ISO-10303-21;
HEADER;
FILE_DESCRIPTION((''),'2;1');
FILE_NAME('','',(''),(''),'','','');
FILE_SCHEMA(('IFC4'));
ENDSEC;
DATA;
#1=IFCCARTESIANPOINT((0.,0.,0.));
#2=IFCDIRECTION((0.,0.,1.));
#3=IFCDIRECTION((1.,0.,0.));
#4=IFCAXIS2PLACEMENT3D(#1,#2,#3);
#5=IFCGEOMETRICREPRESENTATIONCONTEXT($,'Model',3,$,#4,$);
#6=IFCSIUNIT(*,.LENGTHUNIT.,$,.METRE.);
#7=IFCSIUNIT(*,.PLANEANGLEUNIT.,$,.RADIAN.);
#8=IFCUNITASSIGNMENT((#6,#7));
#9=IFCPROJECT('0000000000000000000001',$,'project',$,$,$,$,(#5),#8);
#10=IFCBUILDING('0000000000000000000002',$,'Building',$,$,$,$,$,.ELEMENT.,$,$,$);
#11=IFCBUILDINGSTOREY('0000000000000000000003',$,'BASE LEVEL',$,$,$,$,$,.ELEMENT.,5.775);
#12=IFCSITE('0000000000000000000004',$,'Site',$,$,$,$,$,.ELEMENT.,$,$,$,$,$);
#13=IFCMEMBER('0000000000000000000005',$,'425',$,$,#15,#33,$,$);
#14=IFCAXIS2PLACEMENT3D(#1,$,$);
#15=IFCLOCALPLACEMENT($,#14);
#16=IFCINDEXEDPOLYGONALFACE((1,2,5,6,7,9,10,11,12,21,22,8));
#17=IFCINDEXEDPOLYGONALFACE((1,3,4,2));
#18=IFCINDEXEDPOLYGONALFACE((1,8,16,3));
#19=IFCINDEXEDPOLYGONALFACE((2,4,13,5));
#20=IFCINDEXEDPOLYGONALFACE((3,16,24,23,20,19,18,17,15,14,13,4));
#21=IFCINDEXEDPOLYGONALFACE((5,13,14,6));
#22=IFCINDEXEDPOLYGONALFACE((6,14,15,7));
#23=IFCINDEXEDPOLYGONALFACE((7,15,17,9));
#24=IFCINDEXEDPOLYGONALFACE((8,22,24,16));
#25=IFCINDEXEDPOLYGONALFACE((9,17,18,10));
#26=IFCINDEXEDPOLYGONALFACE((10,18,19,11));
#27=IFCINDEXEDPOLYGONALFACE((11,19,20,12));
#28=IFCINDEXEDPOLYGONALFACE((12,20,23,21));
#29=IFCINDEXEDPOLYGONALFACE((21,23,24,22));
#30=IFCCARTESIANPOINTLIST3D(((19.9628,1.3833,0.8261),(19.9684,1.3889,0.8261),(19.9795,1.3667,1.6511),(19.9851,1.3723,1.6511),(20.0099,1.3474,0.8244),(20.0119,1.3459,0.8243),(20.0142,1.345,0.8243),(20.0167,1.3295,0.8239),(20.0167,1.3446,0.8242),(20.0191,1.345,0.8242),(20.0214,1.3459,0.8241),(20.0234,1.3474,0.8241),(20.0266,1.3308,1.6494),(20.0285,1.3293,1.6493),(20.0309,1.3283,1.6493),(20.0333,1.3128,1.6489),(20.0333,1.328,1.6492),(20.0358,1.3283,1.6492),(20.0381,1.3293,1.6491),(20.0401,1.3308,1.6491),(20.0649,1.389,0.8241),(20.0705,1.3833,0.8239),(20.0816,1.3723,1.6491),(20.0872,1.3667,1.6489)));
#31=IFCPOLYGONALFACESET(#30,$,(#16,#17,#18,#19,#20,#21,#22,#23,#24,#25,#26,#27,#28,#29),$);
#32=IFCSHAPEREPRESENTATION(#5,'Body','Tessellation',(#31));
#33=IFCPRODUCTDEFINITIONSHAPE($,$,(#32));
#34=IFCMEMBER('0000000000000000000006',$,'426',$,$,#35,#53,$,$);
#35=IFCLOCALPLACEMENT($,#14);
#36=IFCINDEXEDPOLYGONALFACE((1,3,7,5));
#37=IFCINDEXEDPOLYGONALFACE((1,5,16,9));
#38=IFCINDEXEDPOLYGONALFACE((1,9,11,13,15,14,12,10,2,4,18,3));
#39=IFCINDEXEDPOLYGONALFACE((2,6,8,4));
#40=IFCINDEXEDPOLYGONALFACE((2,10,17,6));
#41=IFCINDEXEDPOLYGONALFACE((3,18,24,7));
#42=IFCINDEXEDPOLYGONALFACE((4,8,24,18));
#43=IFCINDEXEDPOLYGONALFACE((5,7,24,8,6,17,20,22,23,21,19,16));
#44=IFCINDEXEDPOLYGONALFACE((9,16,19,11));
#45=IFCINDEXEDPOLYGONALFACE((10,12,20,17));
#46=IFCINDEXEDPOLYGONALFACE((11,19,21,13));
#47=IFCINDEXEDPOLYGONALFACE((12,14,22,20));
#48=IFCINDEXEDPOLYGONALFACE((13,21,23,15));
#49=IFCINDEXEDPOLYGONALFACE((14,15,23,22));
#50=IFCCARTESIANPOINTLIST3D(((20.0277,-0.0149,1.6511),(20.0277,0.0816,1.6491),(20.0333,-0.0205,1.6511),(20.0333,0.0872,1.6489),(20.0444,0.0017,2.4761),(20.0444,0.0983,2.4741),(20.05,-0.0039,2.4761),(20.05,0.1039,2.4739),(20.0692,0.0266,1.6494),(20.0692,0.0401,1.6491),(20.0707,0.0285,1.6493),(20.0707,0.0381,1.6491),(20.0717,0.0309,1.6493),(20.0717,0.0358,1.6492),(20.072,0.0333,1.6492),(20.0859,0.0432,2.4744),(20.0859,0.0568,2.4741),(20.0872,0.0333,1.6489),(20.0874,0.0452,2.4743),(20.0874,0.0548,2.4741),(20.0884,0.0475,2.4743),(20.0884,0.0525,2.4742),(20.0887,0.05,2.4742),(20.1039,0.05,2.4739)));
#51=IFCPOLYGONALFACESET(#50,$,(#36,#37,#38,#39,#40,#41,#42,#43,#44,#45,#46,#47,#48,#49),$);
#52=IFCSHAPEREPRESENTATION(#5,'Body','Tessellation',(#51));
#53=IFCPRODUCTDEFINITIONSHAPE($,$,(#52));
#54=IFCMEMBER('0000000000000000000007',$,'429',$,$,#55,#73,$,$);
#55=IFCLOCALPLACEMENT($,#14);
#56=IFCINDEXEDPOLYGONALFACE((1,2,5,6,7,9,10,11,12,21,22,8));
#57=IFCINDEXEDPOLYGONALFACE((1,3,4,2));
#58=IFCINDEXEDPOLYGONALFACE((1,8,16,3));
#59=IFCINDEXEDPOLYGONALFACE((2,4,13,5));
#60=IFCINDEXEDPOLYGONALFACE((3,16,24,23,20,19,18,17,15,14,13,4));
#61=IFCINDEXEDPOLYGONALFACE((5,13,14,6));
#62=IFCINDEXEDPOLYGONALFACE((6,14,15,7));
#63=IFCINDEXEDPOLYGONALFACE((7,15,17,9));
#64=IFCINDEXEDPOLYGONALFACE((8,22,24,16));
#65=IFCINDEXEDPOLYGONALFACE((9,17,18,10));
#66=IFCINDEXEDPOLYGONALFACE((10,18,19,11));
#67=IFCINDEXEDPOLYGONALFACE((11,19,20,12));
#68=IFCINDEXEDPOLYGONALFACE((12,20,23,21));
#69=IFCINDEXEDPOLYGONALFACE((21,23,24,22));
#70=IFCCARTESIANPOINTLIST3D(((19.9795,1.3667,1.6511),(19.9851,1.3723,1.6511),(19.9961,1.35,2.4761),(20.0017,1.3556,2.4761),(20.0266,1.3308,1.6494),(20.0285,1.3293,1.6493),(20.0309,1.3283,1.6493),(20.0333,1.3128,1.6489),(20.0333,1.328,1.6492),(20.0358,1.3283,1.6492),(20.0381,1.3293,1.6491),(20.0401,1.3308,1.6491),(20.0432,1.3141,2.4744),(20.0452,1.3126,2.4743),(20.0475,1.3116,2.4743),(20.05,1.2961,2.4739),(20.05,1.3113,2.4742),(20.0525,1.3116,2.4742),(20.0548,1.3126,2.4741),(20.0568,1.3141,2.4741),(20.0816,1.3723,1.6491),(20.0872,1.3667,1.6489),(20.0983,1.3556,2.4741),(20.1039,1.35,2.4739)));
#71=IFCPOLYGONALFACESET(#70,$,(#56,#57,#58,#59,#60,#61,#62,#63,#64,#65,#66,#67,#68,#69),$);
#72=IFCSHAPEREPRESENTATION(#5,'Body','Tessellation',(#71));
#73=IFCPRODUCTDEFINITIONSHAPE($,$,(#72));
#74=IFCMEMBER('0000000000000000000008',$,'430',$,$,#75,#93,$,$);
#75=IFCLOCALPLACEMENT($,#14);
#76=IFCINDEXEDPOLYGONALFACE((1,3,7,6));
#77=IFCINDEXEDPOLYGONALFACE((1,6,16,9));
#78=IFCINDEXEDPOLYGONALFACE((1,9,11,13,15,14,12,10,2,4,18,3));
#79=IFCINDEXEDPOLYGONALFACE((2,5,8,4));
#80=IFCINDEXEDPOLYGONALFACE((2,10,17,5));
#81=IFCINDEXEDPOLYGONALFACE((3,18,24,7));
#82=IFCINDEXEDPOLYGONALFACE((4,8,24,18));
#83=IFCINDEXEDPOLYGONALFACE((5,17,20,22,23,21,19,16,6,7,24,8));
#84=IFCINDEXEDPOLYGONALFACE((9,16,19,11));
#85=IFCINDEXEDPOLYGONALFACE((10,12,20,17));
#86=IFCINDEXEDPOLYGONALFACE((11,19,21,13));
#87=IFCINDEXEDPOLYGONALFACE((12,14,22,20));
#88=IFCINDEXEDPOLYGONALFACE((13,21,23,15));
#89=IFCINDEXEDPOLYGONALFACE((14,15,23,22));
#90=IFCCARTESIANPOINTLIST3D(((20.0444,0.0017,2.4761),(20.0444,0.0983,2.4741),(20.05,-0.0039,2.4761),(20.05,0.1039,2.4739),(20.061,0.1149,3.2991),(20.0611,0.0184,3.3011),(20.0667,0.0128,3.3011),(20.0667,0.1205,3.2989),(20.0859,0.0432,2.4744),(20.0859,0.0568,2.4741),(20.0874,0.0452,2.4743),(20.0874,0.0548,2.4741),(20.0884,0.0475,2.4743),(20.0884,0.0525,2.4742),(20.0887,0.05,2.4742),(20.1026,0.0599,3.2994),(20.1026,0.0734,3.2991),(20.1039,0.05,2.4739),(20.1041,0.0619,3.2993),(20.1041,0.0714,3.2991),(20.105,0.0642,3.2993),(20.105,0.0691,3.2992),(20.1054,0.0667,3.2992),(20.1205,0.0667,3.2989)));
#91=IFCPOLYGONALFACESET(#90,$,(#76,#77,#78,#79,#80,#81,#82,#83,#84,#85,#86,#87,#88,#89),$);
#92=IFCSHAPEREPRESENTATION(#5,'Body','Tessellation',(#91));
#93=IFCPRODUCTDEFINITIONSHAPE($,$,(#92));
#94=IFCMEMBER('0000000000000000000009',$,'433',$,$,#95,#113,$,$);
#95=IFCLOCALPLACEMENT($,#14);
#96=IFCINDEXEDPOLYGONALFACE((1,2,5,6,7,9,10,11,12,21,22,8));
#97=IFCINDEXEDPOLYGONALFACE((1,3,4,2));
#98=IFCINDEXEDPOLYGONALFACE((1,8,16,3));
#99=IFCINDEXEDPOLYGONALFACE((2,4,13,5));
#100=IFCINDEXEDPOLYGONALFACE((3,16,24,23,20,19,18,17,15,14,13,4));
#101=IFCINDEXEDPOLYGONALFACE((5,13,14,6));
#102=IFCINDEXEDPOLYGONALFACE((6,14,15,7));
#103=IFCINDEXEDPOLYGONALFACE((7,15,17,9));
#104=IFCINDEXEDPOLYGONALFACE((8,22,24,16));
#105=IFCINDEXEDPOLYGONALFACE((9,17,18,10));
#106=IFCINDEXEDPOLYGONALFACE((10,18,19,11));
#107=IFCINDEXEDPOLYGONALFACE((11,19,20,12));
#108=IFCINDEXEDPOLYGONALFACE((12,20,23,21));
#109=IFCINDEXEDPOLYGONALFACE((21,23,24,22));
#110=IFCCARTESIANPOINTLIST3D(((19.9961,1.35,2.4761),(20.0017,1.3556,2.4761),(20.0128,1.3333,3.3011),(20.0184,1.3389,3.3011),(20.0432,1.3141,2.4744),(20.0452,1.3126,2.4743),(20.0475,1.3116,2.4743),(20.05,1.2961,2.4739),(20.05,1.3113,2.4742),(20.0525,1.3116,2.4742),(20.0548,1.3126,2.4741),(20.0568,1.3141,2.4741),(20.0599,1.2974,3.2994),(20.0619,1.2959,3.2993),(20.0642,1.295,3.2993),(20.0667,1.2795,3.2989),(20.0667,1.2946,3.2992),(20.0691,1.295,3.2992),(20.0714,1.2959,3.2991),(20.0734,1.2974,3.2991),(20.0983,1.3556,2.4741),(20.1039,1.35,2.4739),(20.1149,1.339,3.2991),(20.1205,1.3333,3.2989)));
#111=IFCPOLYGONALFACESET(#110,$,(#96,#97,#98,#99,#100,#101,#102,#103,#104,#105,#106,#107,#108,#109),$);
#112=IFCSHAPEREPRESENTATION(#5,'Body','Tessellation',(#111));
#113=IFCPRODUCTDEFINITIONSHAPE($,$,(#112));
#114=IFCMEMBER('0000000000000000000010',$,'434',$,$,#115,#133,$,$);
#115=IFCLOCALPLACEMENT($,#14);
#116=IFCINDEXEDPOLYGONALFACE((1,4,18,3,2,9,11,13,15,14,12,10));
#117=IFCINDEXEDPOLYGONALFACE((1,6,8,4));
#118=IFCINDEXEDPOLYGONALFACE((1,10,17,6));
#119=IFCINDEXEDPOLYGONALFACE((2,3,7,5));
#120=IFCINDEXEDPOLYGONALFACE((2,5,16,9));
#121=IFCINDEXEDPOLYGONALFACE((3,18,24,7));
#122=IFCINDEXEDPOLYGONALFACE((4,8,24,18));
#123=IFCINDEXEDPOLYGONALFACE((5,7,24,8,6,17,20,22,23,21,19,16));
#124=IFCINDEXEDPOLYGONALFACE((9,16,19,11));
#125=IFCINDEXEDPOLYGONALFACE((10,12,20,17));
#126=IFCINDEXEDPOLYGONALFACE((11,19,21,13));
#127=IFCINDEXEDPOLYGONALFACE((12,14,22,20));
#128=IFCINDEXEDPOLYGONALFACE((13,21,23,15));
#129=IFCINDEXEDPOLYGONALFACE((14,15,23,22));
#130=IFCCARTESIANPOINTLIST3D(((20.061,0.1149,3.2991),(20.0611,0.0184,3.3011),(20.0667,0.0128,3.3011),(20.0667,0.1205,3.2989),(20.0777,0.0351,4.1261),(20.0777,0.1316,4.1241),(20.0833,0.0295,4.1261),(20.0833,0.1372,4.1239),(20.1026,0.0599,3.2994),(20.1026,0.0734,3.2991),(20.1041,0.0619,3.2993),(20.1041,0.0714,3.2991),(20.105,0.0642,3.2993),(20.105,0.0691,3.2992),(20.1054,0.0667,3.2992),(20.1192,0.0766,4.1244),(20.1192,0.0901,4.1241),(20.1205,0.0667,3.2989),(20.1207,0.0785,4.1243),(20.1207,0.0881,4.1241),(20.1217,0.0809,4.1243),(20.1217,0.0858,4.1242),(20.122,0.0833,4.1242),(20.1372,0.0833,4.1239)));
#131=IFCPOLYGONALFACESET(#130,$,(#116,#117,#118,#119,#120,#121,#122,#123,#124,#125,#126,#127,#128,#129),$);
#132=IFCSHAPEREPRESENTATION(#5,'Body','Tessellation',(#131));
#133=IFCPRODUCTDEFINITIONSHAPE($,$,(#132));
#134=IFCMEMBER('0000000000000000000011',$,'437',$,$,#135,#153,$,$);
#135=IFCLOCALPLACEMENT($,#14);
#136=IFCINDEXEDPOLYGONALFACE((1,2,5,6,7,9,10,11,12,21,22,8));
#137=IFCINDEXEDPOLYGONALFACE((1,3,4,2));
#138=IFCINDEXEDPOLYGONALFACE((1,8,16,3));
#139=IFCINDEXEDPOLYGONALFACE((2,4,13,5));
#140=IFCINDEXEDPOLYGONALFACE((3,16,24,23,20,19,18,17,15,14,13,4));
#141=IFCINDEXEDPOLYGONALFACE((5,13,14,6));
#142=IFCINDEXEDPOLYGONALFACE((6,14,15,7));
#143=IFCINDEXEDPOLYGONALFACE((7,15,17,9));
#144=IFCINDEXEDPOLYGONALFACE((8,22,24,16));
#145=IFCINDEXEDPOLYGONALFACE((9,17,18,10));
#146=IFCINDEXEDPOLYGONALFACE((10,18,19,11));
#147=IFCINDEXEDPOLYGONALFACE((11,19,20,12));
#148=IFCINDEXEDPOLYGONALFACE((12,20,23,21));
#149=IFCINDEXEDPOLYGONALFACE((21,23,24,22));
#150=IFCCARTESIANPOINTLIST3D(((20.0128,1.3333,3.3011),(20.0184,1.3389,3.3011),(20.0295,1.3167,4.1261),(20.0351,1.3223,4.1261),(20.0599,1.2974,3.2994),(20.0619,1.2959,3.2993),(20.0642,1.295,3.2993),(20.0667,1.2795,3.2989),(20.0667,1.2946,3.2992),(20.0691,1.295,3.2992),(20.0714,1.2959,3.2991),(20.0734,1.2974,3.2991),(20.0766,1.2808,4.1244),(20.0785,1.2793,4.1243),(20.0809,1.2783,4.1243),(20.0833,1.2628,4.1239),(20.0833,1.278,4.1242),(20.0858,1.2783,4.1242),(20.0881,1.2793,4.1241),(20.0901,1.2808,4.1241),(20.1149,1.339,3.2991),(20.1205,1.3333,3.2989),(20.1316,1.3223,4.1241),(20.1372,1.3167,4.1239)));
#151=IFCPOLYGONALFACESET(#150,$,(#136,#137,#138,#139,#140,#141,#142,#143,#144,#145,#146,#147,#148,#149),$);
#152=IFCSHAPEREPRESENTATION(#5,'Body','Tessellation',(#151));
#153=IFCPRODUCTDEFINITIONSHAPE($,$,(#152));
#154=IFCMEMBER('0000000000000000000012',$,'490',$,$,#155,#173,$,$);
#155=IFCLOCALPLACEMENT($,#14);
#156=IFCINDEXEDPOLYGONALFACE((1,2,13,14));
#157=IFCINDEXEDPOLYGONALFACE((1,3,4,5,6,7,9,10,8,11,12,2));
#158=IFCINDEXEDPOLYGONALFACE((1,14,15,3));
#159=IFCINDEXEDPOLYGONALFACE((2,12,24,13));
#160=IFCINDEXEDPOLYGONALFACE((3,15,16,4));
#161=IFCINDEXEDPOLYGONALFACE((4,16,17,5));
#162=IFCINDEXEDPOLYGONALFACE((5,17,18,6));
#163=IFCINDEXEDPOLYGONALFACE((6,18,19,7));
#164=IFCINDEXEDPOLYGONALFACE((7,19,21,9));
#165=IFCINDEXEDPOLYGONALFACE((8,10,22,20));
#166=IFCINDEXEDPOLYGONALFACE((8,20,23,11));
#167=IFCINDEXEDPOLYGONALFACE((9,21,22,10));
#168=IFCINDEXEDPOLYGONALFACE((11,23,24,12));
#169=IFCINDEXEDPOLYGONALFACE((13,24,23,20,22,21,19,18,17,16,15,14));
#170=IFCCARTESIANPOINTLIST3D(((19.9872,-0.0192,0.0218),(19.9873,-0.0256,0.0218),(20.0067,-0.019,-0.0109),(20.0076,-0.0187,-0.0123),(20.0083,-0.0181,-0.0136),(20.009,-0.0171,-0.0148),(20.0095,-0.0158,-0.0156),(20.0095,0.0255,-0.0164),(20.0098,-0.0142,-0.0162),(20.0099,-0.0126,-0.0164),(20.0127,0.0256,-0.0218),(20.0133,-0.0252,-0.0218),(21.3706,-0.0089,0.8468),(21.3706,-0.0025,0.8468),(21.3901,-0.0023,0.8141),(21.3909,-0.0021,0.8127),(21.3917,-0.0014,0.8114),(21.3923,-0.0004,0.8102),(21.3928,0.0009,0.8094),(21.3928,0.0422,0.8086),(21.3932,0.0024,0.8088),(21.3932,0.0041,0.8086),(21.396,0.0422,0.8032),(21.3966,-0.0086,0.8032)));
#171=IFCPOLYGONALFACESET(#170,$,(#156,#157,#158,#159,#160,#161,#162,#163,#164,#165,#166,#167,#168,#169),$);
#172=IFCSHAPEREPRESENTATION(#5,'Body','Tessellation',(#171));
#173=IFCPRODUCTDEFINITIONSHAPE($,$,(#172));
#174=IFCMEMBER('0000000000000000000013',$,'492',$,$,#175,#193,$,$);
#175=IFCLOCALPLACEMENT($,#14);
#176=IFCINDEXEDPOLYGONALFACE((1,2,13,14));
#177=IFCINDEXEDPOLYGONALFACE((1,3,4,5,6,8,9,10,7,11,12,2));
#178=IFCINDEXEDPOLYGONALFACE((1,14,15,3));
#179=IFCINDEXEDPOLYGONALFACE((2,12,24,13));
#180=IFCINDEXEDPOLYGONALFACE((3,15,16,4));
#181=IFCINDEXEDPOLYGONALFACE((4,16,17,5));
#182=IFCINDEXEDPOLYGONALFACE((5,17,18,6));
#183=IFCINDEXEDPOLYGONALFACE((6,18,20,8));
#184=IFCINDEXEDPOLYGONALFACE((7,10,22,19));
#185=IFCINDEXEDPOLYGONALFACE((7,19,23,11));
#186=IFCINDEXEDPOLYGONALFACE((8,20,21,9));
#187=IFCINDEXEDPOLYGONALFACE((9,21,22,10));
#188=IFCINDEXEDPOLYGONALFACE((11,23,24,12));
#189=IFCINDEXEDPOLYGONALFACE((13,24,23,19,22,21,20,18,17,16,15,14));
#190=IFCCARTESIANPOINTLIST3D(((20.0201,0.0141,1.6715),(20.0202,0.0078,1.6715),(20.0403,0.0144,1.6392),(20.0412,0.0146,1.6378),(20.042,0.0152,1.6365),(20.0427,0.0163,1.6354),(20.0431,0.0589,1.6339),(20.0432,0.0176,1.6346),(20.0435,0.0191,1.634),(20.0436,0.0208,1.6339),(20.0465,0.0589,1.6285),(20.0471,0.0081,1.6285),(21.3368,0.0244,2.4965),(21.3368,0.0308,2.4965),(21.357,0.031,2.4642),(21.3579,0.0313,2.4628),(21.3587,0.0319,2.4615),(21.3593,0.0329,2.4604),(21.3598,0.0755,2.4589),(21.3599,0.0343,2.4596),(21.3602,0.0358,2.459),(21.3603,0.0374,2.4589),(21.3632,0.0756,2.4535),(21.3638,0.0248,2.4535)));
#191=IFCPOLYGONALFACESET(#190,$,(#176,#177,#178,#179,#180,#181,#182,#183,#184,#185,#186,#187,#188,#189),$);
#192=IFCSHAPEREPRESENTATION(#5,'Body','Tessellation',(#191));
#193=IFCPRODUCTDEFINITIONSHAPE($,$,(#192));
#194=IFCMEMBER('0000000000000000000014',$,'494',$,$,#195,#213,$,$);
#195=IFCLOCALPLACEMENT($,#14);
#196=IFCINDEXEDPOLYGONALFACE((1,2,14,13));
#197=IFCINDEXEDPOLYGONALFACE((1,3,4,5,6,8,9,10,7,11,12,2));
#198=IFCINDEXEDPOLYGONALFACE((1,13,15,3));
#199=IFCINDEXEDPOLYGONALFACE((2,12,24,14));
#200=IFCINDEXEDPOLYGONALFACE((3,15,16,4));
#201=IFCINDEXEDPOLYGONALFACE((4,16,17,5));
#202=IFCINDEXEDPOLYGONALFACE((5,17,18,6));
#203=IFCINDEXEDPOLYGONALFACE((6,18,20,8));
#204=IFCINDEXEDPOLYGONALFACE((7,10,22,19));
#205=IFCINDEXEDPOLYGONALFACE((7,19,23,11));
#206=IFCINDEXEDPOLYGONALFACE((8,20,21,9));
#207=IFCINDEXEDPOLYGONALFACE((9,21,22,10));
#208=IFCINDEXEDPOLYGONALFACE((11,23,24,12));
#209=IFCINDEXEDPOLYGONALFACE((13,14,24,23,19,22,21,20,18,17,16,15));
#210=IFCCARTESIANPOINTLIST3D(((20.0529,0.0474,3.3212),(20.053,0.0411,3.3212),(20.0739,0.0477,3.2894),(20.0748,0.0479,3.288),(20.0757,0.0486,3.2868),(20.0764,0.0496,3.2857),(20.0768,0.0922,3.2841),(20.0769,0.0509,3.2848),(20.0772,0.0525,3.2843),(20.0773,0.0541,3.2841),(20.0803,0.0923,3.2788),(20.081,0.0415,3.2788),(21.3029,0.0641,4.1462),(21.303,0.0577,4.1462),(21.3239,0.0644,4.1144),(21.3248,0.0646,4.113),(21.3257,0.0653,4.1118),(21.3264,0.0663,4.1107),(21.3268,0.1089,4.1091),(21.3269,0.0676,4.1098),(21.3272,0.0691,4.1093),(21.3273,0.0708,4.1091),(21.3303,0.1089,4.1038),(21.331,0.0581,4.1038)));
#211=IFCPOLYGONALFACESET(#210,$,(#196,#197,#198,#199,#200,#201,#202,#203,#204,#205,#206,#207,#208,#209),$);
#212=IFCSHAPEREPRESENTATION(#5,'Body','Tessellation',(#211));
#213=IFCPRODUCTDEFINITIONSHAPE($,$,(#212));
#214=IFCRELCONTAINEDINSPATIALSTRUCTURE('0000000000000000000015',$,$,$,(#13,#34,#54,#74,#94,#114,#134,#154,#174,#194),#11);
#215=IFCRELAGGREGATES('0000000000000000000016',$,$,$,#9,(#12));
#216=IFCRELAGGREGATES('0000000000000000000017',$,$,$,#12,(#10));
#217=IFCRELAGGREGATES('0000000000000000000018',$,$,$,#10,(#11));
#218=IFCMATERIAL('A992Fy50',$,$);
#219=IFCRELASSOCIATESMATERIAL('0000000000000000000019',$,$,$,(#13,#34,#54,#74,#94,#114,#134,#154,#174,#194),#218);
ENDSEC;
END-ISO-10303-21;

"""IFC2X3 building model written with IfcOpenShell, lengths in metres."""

from ifc_helpers import new_model, si_unit, frame, origin_with_axes, origin_2d_with_axis, place, context, project, spatial, l_section, extrude, material, element, save


model = new_model("IFC2X3")

# Units and contexts
model_context = context("Model", 3, world=origin_with_axes())
ifc_project = project(units=[si_unit("LENGTHUNIT", "METRE"), si_unit("PLANEANGLEUNIT", "RADIAN")], contexts=[model_context])

# Site, building, storey
site = spatial("IfcSite", under=ifc_project, Name="Site", CompositionType="ELEMENT")
building = spatial("IfcBuilding", under=site, Name="Building", CompositionType="ELEMENT")
storey = spatial("IfcBuildingStorey", under=building, Name="BASE LEVEL", CompositionType="ELEMENT", Elevation=5.775)

# Members
ifc_material = material(Name="A992Fy50")
for number, where, z_axis, x_axis, name in (
    (1, (20.0167, 1.3833, 0.825), (0.020194, -0.020194, 0.999592), (0.707107, 0.707107, 0.0), "425"),
    (2, (20.0333, 0.0333, 1.65), (0.020194, 0.020194, 0.999592), (-0.707107, 0.707107, 0.0), "426"),
    (3, (20.0333, 1.3667, 1.65), (0.020194, -0.020194, 0.999592), (0.707107, 0.707107, 0.0), "429"),
    (4, (20.05, 0.05, 2.475), (0.020194, 0.020194, 0.999592), (-0.707107, 0.707107, 0.0), "430"),
    (5, (20.05, 1.35, 2.475), (0.020194, -0.020194, 0.999592), (0.707107, 0.707107, 0.0), "433"),
    (6, (20.0667, 0.0667, 3.3), (0.020194, 0.020194, 0.999592), (-0.707107, 0.707107, 0.0), "434"),
    (7, (20.0667, 1.3333, 3.3), (0.020194, -0.020194, 0.999592), (0.707107, 0.707107, 0.0), "437"),
):
    element("IfcMember", number, at=place(None, frame(where, z_axis=z_axis, x_axis=x_axis)), inside=storey, material=ifc_material, Name=name, context=model_context, shape_type="SweptSolid", body=[
        extrude(l_section(Depth=0.0762, Width=0.0762, Thickness=0.0079, FilletRadius=0.0096, at=origin_2d_with_axis()), origin_with_axes(), (0.0, 0.0, 1.0), 0.8253),
    ])
member_1_placement = place(None, frame((20.0, 0.0, 0.0), z_axis=(0.858813, 0.010347, 0.512184), x_axis=(-0.012047, 0.999927, 0.0)))
element("IfcMember", 8, at=member_1_placement, inside=storey, material=ifc_material, Name="490", context=model_context, shape_type="SweptSolid", body=[
    extrude(l_section(Depth=0.0508, Width=0.0508, Thickness=0.0063, FilletRadius=0.0063, at=origin_2d_with_axis()), origin_with_axes(), (0.0, 0.0, 1.0), 1.6107),
])
member_2_placement = place(None, frame((20.0333, 0.0333, 1.65), z_axis=(0.847346, 0.010726, 0.530932), x_axis=(-0.013332, 0.999911, 0.0)))
element("IfcMember", 9, at=member_2_placement, inside=storey, material=ifc_material, Name="492", context=model_context, shape_type="SweptSolid", body=[
    extrude(l_section(Depth=0.0508, Width=0.0508, Thickness=0.0063, FilletRadius=0.0063, at=origin_2d_with_axis()), origin_with_axes(), (0.0, 0.0, 1.0), 1.5539),
])
member_3_placement = place(None, frame((20.0667, 0.0667, 3.3), z_axis=(0.834558, 0.011127, 0.550808), x_axis=(-0.013332, 0.999911, 0.0)))
element("IfcMember", 10, at=member_3_placement, inside=storey, material=ifc_material, Name="494", context=model_context, shape_type="SweptSolid", body=[
    extrude(l_section(Depth=0.0508, Width=0.0508, Thickness=0.0063, FilletRadius=0.0063, at=origin_2d_with_axis()), origin_with_axes(), (0.0, 0.0, 1.0), 1.4978),
])

save(model, "model.ifc")
